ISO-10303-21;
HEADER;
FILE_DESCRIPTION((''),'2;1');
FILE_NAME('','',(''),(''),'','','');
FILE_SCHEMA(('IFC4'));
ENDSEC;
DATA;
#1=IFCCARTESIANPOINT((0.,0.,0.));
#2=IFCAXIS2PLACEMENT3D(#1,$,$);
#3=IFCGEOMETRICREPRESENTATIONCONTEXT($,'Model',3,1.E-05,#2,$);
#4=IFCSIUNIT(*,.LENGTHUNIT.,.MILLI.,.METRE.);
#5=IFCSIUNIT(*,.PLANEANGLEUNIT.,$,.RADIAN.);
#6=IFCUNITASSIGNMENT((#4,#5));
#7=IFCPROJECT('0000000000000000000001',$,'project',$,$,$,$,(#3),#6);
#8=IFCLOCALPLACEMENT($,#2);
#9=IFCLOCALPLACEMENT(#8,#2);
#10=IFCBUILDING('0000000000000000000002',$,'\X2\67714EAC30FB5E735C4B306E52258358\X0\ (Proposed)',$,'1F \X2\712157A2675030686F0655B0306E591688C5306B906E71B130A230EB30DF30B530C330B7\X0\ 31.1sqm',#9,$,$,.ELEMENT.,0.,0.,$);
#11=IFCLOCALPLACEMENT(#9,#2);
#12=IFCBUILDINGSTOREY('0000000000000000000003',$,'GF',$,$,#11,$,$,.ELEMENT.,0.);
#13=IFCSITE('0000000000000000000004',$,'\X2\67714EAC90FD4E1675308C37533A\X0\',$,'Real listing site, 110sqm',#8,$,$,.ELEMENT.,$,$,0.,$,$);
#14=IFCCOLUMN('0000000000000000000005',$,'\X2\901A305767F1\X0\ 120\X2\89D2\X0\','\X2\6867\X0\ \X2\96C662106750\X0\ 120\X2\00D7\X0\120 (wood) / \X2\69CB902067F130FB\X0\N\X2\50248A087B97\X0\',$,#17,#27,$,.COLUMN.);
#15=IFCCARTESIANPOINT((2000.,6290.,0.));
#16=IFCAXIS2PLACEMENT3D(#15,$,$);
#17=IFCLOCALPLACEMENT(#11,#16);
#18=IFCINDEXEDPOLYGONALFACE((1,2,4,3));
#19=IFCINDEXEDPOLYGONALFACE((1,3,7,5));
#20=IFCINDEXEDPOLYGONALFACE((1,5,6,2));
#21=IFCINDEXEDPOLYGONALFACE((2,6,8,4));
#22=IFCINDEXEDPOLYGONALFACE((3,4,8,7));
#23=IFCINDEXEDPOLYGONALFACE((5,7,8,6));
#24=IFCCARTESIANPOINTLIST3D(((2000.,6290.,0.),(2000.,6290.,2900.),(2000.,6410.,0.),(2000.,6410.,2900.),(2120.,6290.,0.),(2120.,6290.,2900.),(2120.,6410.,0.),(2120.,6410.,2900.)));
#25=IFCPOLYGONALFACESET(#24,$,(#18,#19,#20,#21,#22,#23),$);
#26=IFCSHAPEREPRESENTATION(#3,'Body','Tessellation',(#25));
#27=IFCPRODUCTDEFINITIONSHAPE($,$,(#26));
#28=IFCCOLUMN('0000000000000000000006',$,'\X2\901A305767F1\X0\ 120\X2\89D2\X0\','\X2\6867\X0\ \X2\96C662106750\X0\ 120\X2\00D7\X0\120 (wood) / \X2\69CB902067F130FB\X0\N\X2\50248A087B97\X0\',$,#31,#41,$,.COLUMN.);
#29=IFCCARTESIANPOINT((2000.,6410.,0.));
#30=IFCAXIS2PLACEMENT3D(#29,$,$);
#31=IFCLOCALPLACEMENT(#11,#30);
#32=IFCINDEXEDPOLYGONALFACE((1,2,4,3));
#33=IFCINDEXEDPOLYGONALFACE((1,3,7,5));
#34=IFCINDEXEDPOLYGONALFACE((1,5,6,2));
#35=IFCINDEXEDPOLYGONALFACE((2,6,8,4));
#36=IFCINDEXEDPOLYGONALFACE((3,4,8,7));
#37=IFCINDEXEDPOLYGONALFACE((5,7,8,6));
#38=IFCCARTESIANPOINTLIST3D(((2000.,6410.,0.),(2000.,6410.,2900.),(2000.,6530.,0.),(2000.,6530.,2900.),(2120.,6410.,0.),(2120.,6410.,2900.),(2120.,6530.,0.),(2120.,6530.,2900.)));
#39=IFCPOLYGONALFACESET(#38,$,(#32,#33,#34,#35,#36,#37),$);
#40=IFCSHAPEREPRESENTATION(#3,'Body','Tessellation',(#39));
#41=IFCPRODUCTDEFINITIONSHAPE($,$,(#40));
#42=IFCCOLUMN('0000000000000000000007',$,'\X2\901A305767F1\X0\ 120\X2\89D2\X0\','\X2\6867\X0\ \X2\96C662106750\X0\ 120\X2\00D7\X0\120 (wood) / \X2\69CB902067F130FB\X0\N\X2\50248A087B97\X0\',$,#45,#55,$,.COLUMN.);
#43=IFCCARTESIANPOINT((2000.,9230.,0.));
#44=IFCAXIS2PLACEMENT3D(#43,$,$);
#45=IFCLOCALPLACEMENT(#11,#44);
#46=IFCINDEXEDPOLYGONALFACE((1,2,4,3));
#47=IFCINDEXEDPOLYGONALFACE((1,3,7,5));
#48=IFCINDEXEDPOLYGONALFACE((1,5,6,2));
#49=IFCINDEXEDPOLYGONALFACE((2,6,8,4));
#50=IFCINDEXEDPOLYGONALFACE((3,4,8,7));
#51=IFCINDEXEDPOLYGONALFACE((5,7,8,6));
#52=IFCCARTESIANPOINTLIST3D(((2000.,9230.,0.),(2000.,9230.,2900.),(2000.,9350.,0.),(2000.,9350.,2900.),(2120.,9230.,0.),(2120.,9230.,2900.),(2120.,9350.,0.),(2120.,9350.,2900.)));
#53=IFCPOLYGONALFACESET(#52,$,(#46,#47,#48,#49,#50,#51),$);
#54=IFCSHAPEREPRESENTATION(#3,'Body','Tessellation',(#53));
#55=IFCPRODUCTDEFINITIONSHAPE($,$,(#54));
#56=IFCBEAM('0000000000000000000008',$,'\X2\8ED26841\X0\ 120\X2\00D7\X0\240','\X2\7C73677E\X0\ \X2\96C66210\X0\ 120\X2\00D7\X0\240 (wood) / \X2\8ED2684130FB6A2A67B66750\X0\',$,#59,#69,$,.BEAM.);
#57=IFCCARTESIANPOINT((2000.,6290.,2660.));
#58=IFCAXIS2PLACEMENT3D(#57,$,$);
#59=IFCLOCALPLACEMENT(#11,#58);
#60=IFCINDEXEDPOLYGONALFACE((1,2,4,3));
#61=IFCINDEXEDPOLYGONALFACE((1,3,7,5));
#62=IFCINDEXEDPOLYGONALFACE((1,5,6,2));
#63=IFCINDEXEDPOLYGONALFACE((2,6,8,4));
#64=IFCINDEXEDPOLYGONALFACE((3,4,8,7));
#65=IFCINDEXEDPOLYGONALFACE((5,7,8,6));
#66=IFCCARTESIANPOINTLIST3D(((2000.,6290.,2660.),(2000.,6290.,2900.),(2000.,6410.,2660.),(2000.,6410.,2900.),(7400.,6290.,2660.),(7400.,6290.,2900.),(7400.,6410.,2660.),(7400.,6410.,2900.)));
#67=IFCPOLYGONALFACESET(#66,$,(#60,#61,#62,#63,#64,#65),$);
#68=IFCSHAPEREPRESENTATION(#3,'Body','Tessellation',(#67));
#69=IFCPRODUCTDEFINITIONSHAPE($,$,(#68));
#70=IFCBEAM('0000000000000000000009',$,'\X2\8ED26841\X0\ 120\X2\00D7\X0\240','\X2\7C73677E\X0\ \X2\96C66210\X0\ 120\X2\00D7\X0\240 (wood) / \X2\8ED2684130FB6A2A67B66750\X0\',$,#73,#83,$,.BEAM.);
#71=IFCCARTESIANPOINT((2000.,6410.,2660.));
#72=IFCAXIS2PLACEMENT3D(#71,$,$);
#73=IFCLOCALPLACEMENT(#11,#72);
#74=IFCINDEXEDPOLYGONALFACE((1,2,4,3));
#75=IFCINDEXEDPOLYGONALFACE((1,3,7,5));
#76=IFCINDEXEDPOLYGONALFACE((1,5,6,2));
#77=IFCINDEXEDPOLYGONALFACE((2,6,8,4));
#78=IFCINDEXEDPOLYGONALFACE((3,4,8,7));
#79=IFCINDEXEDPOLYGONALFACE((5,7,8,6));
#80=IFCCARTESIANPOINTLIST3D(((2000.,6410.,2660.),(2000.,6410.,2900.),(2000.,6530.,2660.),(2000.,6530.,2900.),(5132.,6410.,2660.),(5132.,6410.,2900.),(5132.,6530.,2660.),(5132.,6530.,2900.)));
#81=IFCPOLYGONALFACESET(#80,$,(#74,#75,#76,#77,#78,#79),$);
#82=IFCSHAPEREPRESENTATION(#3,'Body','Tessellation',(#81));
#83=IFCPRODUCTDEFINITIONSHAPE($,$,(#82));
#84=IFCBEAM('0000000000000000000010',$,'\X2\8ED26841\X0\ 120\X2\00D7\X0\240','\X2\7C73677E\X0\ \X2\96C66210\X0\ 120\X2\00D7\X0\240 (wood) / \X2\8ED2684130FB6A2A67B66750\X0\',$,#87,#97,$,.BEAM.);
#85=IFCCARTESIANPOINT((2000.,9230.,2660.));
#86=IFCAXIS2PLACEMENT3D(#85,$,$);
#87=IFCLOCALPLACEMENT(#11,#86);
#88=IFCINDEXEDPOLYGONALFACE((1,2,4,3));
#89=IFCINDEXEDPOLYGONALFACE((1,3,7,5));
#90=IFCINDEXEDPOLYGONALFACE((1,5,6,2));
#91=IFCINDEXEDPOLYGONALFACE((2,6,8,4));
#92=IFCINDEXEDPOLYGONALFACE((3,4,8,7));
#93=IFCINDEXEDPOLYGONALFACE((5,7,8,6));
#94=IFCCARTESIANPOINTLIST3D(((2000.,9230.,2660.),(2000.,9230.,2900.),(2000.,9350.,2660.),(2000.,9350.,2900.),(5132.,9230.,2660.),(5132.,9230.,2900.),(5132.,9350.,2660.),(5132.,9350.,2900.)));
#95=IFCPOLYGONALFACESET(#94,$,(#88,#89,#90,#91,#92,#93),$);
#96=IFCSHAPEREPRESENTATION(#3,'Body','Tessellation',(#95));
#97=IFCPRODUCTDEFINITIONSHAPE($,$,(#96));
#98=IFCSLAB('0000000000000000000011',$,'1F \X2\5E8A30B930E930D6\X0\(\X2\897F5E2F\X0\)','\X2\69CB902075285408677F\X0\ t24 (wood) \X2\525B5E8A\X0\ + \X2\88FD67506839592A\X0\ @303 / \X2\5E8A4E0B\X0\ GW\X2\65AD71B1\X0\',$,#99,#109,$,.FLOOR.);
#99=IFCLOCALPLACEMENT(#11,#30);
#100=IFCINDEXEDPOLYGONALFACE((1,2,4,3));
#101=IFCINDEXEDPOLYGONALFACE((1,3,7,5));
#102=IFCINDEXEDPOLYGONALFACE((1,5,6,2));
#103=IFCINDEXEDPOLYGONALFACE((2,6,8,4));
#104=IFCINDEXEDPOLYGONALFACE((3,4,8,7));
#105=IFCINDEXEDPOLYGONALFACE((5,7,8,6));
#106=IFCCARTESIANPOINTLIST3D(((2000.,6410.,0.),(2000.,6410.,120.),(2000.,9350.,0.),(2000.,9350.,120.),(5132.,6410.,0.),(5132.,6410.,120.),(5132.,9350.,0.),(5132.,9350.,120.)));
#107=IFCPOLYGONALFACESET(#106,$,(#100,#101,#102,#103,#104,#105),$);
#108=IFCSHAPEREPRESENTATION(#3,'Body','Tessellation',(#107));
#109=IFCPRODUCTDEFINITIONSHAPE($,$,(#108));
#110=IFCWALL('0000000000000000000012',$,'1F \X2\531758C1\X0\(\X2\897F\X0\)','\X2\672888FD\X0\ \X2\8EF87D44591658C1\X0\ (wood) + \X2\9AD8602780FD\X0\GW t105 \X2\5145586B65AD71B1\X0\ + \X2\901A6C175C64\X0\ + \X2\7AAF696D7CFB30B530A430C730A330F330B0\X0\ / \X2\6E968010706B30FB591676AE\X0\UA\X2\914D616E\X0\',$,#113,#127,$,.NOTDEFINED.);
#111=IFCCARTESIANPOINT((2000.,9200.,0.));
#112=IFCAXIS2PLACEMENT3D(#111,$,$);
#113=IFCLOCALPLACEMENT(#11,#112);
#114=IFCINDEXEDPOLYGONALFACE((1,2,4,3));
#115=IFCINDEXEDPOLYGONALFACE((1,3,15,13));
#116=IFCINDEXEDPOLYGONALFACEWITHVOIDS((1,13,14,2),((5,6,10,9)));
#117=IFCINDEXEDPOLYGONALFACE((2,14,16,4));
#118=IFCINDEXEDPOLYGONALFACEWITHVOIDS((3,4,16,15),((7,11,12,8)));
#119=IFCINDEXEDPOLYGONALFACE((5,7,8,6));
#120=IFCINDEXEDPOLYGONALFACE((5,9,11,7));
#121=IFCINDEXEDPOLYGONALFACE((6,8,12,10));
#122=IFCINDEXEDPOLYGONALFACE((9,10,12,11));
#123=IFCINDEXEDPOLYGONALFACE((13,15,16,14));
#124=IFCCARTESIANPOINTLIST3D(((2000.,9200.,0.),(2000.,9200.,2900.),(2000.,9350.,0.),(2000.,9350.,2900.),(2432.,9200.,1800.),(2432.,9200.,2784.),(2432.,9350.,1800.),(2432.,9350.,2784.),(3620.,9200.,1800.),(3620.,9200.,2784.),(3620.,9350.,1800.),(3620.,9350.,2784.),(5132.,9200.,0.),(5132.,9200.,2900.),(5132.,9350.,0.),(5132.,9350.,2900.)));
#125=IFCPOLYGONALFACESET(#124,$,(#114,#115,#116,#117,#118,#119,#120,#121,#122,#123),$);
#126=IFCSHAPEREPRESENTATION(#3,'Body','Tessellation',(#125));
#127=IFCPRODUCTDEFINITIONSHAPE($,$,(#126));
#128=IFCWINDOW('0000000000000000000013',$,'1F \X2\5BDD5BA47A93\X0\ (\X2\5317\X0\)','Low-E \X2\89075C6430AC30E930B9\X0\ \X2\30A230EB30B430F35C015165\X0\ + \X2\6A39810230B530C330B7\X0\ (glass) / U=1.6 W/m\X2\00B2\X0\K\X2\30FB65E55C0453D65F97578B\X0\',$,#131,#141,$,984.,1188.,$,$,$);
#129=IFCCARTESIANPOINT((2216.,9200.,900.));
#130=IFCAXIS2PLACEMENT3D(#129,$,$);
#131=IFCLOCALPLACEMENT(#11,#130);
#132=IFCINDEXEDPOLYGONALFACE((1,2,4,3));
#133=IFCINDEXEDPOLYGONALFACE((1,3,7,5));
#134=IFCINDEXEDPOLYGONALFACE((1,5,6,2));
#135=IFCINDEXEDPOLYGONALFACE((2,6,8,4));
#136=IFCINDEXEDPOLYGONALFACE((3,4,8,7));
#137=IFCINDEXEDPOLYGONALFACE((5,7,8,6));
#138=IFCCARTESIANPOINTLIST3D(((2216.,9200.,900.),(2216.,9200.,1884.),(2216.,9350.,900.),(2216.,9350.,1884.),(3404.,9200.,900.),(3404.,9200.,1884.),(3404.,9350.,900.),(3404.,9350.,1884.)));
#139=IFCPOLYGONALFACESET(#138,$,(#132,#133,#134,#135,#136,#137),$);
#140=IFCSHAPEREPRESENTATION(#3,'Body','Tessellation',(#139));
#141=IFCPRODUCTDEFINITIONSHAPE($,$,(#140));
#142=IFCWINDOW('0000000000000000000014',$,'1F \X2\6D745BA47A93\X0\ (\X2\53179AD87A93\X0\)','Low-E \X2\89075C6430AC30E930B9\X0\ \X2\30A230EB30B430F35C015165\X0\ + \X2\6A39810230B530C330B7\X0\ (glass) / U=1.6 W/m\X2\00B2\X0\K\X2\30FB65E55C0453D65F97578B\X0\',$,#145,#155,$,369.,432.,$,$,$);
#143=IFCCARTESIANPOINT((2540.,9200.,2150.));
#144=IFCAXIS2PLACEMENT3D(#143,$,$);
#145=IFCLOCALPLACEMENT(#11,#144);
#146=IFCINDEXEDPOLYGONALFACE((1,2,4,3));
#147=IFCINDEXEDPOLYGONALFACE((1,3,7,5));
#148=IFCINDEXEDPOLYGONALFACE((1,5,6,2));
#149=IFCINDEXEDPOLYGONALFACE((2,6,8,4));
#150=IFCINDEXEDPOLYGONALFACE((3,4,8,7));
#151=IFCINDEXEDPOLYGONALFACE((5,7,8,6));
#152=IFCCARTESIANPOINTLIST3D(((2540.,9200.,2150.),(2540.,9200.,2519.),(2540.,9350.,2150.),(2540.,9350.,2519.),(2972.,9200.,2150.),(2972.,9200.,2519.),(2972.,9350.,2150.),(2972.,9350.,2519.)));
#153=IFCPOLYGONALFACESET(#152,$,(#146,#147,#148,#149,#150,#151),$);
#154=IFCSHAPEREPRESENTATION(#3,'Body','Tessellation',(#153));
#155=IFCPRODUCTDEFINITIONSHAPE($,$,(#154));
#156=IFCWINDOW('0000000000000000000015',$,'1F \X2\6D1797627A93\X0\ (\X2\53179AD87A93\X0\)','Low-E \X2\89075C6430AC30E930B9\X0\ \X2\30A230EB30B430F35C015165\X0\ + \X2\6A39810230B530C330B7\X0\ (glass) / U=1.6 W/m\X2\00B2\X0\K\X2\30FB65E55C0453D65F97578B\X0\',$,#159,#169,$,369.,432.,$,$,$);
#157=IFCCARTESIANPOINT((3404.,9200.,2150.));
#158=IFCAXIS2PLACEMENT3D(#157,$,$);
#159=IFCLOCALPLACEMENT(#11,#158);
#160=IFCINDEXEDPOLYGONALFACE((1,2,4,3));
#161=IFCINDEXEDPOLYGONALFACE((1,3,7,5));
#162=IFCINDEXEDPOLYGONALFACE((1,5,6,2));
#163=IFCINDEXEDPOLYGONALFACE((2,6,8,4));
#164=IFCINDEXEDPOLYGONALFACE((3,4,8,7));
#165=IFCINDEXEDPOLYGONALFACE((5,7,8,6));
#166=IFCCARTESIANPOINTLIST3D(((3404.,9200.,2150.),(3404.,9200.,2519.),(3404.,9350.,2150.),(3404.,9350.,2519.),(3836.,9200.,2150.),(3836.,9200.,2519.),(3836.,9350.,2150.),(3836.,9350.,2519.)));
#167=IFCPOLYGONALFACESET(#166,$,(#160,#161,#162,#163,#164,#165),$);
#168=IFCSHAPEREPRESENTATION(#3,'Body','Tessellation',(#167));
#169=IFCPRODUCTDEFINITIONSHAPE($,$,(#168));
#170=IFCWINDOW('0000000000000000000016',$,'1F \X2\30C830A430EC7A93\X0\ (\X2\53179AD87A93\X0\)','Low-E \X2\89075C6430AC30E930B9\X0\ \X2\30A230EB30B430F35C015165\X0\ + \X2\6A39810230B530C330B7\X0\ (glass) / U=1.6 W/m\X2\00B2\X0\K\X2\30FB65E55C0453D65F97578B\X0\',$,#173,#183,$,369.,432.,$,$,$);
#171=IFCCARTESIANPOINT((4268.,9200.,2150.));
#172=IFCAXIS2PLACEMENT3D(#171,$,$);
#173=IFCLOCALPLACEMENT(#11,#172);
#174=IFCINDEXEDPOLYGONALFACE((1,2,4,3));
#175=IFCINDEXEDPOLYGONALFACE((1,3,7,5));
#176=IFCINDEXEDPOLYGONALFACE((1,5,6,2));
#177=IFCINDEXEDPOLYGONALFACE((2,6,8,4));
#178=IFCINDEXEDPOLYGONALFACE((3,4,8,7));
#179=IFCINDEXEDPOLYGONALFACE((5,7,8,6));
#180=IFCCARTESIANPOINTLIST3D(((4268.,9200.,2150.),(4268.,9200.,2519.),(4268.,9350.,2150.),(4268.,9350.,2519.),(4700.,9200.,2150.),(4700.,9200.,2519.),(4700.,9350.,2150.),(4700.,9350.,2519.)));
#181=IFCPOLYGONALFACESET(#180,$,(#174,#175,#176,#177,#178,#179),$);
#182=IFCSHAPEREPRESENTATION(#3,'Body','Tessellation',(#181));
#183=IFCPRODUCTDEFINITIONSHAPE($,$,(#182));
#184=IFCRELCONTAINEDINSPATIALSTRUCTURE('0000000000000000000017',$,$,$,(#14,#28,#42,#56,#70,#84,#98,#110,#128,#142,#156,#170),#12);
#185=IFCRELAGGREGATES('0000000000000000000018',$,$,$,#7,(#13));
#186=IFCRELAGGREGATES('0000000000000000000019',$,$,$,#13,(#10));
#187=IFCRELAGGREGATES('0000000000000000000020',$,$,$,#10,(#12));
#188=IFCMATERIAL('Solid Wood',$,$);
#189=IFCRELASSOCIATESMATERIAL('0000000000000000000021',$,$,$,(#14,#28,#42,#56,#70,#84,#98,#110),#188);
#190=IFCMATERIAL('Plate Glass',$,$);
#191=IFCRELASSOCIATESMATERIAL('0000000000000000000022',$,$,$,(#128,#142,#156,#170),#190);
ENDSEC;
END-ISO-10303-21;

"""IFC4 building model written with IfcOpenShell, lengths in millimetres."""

from ifc_helpers import new_model, si_unit, frame, frame_2d, origin, place, context, project, spatial, rectangle, extrude, material, element, fill, save


model = new_model("IFC4")

# Units and contexts
model_context = context("Model", 3, precision=1e-05, world=origin())
ifc_project = project(units=[si_unit("LENGTHUNIT", "METRE", prefix="MILLI"), si_unit("PLANEANGLEUNIT", "RADIAN")], contexts=[model_context])

# Site, building, storey
site_placement = place(None, origin())
site = spatial("IfcSite", under=ifc_project, at=site_placement, Name="東京都世田谷区", ObjectType="Real listing site, 110sqm", CompositionType="ELEMENT", RefElevation=0.0)
building_placement = place(site_placement, origin())
building = spatial("IfcBuilding", under=site, at=building_placement, Name="東京・平屋の別荘 (Proposed)", ObjectType="1F 無垢材と漆喰の外装に遮熱アルミサッシ 31.1sqm", CompositionType="ELEMENT", ElevationOfRefHeight=0.0, ElevationOfTerrain=0.0)
storey_placement = place(building_placement, origin())
storey = spatial("IfcBuildingStorey", under=building, at=storey_placement, Name="GF", CompositionType="ELEMENT", Elevation=0.0)

# Columns
ifc_material_1 = material(Name="Solid Wood")
column_1_placement = place(storey_placement, frame((2000.0, 6290.0, 0.0)))
element("IfcColumn", 1, at=column_1_placement, inside=storey, material=ifc_material_1, Name="通し柱 120角", Description="桧 集成材 120×120 (wood) / 構造柱・N値計算", PredefinedType="COLUMN", context=model_context, shape_type="SweptSolid", body=[
    extrude(rectangle(XDim=120.0, YDim=120.0, at=frame_2d((60.0, 60.0))), frame((2000.0, 6290.0, 0.0)), (0.0, 0.0, 1.0), 2900.0),
])
column_2_placement = place(storey_placement, frame((2000.0, 6410.0, 0.0)))
element("IfcColumn", 2, at=column_2_placement, inside=storey, material=ifc_material_1, Name="通し柱 120角", Description="桧 集成材 120×120 (wood) / 構造柱・N値計算", PredefinedType="COLUMN", context=model_context, shape_type="SweptSolid", body=[
    extrude(rectangle(XDim=120.0, YDim=120.0, at=frame_2d((60.0, 60.0))), frame((2000.0, 6410.0, 0.0)), (0.0, 0.0, 1.0), 2900.0),
])
column_3_placement = place(storey_placement, frame((2000.0, 9230.0, 0.0)))
element("IfcColumn", 3, at=column_3_placement, inside=storey, material=ifc_material_1, Name="通し柱 120角", Description="桧 集成材 120×120 (wood) / 構造柱・N値計算", PredefinedType="COLUMN", context=model_context, shape_type="SweptSolid", body=[
    extrude(rectangle(XDim=120.0, YDim=120.0, at=frame_2d((60.0, 60.0))), frame((2000.0, 9230.0, 0.0)), (0.0, 0.0, 1.0), 2900.0),
])

# Beams
beam_1_placement = place(storey_placement, frame((2000.0, 6290.0, 2660.0)))
element("IfcBeam", 4, at=beam_1_placement, inside=storey, material=ifc_material_1, Name="軒桁 120×240", Description="米松 集成 120×240 (wood) / 軒桁・横架材", PredefinedType="BEAM", context=model_context, shape_type="SweptSolid", body=[
    extrude(rectangle(XDim=5400.0, YDim=120.0, at=frame_2d((2700.0, 60.0))), frame((2000.0, 6290.0, 2660.0)), (0.0, 0.0, 1.0), 240.0),
])
beam_2_placement = place(storey_placement, frame((2000.0, 6410.0, 2660.0)))
element("IfcBeam", 5, at=beam_2_placement, inside=storey, material=ifc_material_1, Name="軒桁 120×240", Description="米松 集成 120×240 (wood) / 軒桁・横架材", PredefinedType="BEAM", context=model_context, shape_type="SweptSolid", body=[
    extrude(rectangle(XDim=3132.0, YDim=120.0, at=frame_2d((1566.0, 60.0))), frame((2000.0, 6410.0, 2660.0)), (0.0, 0.0, 1.0), 240.0),
])
beam_3_placement = place(storey_placement, frame((2000.0, 9230.0, 2660.0)))
element("IfcBeam", 6, at=beam_3_placement, inside=storey, material=ifc_material_1, Name="軒桁 120×240", Description="米松 集成 120×240 (wood) / 軒桁・横架材", PredefinedType="BEAM", context=model_context, shape_type="SweptSolid", body=[
    extrude(rectangle(XDim=3132.0, YDim=120.0, at=frame_2d((1566.0, 60.0))), frame((2000.0, 9230.0, 2660.0)), (0.0, 0.0, 1.0), 240.0),
])

# Slab
slab_placement = place(storey_placement, frame((2000.0, 6410.0, 0.0)))
element("IfcSlab", 7, at=slab_placement, inside=storey, material=ifc_material_1, Name="1F 床スラブ(西帯)", Description="構造用合板 t24 (wood) 剛床 + 製材根太 @303 / 床下 GW断熱", PredefinedType="FLOOR", context=model_context, shape_type="SweptSolid", body=[
    extrude(rectangle(XDim=3132.0, YDim=2940.0, at=frame_2d((1566.0, 1470.0))), frame((2000.0, 6410.0, 0.0)), (0.0, 0.0, 1.0), 120.0),
])

# Wall, openings, windows
wall_1_placement = place(storey_placement, frame((2000.0, 9200.0, 0.0)))
wall_1 = element("IfcWall", 8, at=wall_1_placement, inside=storey, material=ifc_material_1, Name="1F 北壁(西)", Description="木製 軸組外壁 (wood) + 高性能GW t105 充填断熱 + 通気層 + 窯業系サイディング / 準耐火・外皮UA配慮", PredefinedType="NOTDEFINED", context=model_context, shape_type="SweptSolid", body=[
    extrude(rectangle(XDim=3132.0, YDim=150.0, at=frame_2d((1566.0, 75.0))), frame((2000.0, 9200.0, 0.0)), (0.0, 0.0, 1.0), 2900.0),
])
opening_1_placement = place(storey_placement, frame((2216.0, 9200.0, 900.0)))
opening_1 = element("IfcOpeningElement", 9, at=opening_1_placement, cuts=wall_1, PredefinedType="NOTDEFINED", context=model_context, shape_type="SweptSolid", body=[
    extrude(rectangle(XDim=1188.0, YDim=150.0, at=frame_2d((594.0, 75.0))), frame((2216.0, 9200.0, 900.0)), (0.0, 0.0, 1.0), 984.0),
])
opening_2_placement = place(storey_placement, frame((2540.0, 9200.0, 2150.0)))
opening_2 = element("IfcOpeningElement", 10, at=opening_2_placement, cuts=wall_1, PredefinedType="NOTDEFINED", context=model_context, shape_type="SweptSolid", body=[
    extrude(rectangle(XDim=432.0, YDim=150.0, at=frame_2d((216.0, 75.0))), frame((2540.0, 9200.0, 2150.0)), (0.0, 0.0, 1.0), 369.0),
])
opening_3_placement = place(storey_placement, frame((3404.0, 9200.0, 2150.0)))
opening_3 = element("IfcOpeningElement", 11, at=opening_3_placement, cuts=wall_1, PredefinedType="NOTDEFINED", context=model_context, shape_type="SweptSolid", body=[
    extrude(rectangle(XDim=432.0, YDim=150.0, at=frame_2d((216.0, 75.0))), frame((3404.0, 9200.0, 2150.0)), (0.0, 0.0, 1.0), 369.0),
])
opening_4_placement = place(storey_placement, frame((4268.0, 9200.0, 2150.0)))
opening_4 = element("IfcOpeningElement", 12, at=opening_4_placement, cuts=wall_1, PredefinedType="NOTDEFINED", context=model_context, shape_type="SweptSolid", body=[
    extrude(rectangle(XDim=432.0, YDim=150.0, at=frame_2d((216.0, 75.0))), frame((4268.0, 9200.0, 2150.0)), (0.0, 0.0, 1.0), 369.0),
])
ifc_material_2 = material(Name="Plate Glass")
window_1_placement = place(storey_placement, frame((2216.0, 9200.0, 900.0)))
window_1 = element("IfcWindow", 13, at=window_1_placement, inside=storey, material=ifc_material_2, Name="1F 寝室窓 (北)", Description="Low-E 複層ガラス アルゴン封入 + 樹脂サッシ (glass) / U=1.6 W/m²K・日射取得型", OverallHeight=984.0, OverallWidth=1188.0, context=model_context, shape_type="SweptSolid", body=[
    extrude(rectangle(XDim=1188.0, YDim=150.0, at=frame_2d((594.0, 75.0))), frame((2216.0, 9200.0, 900.0)), (0.0, 0.0, 1.0), 984.0),
])
fill(opening_1, window_1)
window_2_placement = place(storey_placement, frame((2540.0, 9200.0, 2150.0)))
window_2 = element("IfcWindow", 14, at=window_2_placement, inside=storey, material=ifc_material_2, Name="1F 浴室窓 (北高窓)", Description="Low-E 複層ガラス アルゴン封入 + 樹脂サッシ (glass) / U=1.6 W/m²K・日射取得型", OverallHeight=369.0, OverallWidth=432.0, context=model_context, shape_type="SweptSolid", body=[
    extrude(rectangle(XDim=432.0, YDim=150.0, at=frame_2d((216.0, 75.0))), frame((2540.0, 9200.0, 2150.0)), (0.0, 0.0, 1.0), 369.0),
])
fill(opening_2, window_2)
window_3_placement = place(storey_placement, frame((3404.0, 9200.0, 2150.0)))
window_3 = element("IfcWindow", 15, at=window_3_placement, inside=storey, material=ifc_material_2, Name="1F 洗面窓 (北高窓)", Description="Low-E 複層ガラス アルゴン封入 + 樹脂サッシ (glass) / U=1.6 W/m²K・日射取得型", OverallHeight=369.0, OverallWidth=432.0, context=model_context, shape_type="SweptSolid", body=[
    extrude(rectangle(XDim=432.0, YDim=150.0, at=frame_2d((216.0, 75.0))), frame((3404.0, 9200.0, 2150.0)), (0.0, 0.0, 1.0), 369.0),
])
fill(opening_3, window_3)
window_4_placement = place(storey_placement, frame((4268.0, 9200.0, 2150.0)))
window_4 = element("IfcWindow", 16, at=window_4_placement, inside=storey, material=ifc_material_2, Name="1F トイレ窓 (北高窓)", Description="Low-E 複層ガラス アルゴン封入 + 樹脂サッシ (glass) / U=1.6 W/m²K・日射取得型", OverallHeight=369.0, OverallWidth=432.0, context=model_context, shape_type="SweptSolid", body=[
    extrude(rectangle(XDim=432.0, YDim=150.0, at=frame_2d((216.0, 75.0))), frame((4268.0, 9200.0, 2150.0)), (0.0, 0.0, 1.0), 369.0),
])
fill(opening_4, window_4)

save(model, "model.ifc")
